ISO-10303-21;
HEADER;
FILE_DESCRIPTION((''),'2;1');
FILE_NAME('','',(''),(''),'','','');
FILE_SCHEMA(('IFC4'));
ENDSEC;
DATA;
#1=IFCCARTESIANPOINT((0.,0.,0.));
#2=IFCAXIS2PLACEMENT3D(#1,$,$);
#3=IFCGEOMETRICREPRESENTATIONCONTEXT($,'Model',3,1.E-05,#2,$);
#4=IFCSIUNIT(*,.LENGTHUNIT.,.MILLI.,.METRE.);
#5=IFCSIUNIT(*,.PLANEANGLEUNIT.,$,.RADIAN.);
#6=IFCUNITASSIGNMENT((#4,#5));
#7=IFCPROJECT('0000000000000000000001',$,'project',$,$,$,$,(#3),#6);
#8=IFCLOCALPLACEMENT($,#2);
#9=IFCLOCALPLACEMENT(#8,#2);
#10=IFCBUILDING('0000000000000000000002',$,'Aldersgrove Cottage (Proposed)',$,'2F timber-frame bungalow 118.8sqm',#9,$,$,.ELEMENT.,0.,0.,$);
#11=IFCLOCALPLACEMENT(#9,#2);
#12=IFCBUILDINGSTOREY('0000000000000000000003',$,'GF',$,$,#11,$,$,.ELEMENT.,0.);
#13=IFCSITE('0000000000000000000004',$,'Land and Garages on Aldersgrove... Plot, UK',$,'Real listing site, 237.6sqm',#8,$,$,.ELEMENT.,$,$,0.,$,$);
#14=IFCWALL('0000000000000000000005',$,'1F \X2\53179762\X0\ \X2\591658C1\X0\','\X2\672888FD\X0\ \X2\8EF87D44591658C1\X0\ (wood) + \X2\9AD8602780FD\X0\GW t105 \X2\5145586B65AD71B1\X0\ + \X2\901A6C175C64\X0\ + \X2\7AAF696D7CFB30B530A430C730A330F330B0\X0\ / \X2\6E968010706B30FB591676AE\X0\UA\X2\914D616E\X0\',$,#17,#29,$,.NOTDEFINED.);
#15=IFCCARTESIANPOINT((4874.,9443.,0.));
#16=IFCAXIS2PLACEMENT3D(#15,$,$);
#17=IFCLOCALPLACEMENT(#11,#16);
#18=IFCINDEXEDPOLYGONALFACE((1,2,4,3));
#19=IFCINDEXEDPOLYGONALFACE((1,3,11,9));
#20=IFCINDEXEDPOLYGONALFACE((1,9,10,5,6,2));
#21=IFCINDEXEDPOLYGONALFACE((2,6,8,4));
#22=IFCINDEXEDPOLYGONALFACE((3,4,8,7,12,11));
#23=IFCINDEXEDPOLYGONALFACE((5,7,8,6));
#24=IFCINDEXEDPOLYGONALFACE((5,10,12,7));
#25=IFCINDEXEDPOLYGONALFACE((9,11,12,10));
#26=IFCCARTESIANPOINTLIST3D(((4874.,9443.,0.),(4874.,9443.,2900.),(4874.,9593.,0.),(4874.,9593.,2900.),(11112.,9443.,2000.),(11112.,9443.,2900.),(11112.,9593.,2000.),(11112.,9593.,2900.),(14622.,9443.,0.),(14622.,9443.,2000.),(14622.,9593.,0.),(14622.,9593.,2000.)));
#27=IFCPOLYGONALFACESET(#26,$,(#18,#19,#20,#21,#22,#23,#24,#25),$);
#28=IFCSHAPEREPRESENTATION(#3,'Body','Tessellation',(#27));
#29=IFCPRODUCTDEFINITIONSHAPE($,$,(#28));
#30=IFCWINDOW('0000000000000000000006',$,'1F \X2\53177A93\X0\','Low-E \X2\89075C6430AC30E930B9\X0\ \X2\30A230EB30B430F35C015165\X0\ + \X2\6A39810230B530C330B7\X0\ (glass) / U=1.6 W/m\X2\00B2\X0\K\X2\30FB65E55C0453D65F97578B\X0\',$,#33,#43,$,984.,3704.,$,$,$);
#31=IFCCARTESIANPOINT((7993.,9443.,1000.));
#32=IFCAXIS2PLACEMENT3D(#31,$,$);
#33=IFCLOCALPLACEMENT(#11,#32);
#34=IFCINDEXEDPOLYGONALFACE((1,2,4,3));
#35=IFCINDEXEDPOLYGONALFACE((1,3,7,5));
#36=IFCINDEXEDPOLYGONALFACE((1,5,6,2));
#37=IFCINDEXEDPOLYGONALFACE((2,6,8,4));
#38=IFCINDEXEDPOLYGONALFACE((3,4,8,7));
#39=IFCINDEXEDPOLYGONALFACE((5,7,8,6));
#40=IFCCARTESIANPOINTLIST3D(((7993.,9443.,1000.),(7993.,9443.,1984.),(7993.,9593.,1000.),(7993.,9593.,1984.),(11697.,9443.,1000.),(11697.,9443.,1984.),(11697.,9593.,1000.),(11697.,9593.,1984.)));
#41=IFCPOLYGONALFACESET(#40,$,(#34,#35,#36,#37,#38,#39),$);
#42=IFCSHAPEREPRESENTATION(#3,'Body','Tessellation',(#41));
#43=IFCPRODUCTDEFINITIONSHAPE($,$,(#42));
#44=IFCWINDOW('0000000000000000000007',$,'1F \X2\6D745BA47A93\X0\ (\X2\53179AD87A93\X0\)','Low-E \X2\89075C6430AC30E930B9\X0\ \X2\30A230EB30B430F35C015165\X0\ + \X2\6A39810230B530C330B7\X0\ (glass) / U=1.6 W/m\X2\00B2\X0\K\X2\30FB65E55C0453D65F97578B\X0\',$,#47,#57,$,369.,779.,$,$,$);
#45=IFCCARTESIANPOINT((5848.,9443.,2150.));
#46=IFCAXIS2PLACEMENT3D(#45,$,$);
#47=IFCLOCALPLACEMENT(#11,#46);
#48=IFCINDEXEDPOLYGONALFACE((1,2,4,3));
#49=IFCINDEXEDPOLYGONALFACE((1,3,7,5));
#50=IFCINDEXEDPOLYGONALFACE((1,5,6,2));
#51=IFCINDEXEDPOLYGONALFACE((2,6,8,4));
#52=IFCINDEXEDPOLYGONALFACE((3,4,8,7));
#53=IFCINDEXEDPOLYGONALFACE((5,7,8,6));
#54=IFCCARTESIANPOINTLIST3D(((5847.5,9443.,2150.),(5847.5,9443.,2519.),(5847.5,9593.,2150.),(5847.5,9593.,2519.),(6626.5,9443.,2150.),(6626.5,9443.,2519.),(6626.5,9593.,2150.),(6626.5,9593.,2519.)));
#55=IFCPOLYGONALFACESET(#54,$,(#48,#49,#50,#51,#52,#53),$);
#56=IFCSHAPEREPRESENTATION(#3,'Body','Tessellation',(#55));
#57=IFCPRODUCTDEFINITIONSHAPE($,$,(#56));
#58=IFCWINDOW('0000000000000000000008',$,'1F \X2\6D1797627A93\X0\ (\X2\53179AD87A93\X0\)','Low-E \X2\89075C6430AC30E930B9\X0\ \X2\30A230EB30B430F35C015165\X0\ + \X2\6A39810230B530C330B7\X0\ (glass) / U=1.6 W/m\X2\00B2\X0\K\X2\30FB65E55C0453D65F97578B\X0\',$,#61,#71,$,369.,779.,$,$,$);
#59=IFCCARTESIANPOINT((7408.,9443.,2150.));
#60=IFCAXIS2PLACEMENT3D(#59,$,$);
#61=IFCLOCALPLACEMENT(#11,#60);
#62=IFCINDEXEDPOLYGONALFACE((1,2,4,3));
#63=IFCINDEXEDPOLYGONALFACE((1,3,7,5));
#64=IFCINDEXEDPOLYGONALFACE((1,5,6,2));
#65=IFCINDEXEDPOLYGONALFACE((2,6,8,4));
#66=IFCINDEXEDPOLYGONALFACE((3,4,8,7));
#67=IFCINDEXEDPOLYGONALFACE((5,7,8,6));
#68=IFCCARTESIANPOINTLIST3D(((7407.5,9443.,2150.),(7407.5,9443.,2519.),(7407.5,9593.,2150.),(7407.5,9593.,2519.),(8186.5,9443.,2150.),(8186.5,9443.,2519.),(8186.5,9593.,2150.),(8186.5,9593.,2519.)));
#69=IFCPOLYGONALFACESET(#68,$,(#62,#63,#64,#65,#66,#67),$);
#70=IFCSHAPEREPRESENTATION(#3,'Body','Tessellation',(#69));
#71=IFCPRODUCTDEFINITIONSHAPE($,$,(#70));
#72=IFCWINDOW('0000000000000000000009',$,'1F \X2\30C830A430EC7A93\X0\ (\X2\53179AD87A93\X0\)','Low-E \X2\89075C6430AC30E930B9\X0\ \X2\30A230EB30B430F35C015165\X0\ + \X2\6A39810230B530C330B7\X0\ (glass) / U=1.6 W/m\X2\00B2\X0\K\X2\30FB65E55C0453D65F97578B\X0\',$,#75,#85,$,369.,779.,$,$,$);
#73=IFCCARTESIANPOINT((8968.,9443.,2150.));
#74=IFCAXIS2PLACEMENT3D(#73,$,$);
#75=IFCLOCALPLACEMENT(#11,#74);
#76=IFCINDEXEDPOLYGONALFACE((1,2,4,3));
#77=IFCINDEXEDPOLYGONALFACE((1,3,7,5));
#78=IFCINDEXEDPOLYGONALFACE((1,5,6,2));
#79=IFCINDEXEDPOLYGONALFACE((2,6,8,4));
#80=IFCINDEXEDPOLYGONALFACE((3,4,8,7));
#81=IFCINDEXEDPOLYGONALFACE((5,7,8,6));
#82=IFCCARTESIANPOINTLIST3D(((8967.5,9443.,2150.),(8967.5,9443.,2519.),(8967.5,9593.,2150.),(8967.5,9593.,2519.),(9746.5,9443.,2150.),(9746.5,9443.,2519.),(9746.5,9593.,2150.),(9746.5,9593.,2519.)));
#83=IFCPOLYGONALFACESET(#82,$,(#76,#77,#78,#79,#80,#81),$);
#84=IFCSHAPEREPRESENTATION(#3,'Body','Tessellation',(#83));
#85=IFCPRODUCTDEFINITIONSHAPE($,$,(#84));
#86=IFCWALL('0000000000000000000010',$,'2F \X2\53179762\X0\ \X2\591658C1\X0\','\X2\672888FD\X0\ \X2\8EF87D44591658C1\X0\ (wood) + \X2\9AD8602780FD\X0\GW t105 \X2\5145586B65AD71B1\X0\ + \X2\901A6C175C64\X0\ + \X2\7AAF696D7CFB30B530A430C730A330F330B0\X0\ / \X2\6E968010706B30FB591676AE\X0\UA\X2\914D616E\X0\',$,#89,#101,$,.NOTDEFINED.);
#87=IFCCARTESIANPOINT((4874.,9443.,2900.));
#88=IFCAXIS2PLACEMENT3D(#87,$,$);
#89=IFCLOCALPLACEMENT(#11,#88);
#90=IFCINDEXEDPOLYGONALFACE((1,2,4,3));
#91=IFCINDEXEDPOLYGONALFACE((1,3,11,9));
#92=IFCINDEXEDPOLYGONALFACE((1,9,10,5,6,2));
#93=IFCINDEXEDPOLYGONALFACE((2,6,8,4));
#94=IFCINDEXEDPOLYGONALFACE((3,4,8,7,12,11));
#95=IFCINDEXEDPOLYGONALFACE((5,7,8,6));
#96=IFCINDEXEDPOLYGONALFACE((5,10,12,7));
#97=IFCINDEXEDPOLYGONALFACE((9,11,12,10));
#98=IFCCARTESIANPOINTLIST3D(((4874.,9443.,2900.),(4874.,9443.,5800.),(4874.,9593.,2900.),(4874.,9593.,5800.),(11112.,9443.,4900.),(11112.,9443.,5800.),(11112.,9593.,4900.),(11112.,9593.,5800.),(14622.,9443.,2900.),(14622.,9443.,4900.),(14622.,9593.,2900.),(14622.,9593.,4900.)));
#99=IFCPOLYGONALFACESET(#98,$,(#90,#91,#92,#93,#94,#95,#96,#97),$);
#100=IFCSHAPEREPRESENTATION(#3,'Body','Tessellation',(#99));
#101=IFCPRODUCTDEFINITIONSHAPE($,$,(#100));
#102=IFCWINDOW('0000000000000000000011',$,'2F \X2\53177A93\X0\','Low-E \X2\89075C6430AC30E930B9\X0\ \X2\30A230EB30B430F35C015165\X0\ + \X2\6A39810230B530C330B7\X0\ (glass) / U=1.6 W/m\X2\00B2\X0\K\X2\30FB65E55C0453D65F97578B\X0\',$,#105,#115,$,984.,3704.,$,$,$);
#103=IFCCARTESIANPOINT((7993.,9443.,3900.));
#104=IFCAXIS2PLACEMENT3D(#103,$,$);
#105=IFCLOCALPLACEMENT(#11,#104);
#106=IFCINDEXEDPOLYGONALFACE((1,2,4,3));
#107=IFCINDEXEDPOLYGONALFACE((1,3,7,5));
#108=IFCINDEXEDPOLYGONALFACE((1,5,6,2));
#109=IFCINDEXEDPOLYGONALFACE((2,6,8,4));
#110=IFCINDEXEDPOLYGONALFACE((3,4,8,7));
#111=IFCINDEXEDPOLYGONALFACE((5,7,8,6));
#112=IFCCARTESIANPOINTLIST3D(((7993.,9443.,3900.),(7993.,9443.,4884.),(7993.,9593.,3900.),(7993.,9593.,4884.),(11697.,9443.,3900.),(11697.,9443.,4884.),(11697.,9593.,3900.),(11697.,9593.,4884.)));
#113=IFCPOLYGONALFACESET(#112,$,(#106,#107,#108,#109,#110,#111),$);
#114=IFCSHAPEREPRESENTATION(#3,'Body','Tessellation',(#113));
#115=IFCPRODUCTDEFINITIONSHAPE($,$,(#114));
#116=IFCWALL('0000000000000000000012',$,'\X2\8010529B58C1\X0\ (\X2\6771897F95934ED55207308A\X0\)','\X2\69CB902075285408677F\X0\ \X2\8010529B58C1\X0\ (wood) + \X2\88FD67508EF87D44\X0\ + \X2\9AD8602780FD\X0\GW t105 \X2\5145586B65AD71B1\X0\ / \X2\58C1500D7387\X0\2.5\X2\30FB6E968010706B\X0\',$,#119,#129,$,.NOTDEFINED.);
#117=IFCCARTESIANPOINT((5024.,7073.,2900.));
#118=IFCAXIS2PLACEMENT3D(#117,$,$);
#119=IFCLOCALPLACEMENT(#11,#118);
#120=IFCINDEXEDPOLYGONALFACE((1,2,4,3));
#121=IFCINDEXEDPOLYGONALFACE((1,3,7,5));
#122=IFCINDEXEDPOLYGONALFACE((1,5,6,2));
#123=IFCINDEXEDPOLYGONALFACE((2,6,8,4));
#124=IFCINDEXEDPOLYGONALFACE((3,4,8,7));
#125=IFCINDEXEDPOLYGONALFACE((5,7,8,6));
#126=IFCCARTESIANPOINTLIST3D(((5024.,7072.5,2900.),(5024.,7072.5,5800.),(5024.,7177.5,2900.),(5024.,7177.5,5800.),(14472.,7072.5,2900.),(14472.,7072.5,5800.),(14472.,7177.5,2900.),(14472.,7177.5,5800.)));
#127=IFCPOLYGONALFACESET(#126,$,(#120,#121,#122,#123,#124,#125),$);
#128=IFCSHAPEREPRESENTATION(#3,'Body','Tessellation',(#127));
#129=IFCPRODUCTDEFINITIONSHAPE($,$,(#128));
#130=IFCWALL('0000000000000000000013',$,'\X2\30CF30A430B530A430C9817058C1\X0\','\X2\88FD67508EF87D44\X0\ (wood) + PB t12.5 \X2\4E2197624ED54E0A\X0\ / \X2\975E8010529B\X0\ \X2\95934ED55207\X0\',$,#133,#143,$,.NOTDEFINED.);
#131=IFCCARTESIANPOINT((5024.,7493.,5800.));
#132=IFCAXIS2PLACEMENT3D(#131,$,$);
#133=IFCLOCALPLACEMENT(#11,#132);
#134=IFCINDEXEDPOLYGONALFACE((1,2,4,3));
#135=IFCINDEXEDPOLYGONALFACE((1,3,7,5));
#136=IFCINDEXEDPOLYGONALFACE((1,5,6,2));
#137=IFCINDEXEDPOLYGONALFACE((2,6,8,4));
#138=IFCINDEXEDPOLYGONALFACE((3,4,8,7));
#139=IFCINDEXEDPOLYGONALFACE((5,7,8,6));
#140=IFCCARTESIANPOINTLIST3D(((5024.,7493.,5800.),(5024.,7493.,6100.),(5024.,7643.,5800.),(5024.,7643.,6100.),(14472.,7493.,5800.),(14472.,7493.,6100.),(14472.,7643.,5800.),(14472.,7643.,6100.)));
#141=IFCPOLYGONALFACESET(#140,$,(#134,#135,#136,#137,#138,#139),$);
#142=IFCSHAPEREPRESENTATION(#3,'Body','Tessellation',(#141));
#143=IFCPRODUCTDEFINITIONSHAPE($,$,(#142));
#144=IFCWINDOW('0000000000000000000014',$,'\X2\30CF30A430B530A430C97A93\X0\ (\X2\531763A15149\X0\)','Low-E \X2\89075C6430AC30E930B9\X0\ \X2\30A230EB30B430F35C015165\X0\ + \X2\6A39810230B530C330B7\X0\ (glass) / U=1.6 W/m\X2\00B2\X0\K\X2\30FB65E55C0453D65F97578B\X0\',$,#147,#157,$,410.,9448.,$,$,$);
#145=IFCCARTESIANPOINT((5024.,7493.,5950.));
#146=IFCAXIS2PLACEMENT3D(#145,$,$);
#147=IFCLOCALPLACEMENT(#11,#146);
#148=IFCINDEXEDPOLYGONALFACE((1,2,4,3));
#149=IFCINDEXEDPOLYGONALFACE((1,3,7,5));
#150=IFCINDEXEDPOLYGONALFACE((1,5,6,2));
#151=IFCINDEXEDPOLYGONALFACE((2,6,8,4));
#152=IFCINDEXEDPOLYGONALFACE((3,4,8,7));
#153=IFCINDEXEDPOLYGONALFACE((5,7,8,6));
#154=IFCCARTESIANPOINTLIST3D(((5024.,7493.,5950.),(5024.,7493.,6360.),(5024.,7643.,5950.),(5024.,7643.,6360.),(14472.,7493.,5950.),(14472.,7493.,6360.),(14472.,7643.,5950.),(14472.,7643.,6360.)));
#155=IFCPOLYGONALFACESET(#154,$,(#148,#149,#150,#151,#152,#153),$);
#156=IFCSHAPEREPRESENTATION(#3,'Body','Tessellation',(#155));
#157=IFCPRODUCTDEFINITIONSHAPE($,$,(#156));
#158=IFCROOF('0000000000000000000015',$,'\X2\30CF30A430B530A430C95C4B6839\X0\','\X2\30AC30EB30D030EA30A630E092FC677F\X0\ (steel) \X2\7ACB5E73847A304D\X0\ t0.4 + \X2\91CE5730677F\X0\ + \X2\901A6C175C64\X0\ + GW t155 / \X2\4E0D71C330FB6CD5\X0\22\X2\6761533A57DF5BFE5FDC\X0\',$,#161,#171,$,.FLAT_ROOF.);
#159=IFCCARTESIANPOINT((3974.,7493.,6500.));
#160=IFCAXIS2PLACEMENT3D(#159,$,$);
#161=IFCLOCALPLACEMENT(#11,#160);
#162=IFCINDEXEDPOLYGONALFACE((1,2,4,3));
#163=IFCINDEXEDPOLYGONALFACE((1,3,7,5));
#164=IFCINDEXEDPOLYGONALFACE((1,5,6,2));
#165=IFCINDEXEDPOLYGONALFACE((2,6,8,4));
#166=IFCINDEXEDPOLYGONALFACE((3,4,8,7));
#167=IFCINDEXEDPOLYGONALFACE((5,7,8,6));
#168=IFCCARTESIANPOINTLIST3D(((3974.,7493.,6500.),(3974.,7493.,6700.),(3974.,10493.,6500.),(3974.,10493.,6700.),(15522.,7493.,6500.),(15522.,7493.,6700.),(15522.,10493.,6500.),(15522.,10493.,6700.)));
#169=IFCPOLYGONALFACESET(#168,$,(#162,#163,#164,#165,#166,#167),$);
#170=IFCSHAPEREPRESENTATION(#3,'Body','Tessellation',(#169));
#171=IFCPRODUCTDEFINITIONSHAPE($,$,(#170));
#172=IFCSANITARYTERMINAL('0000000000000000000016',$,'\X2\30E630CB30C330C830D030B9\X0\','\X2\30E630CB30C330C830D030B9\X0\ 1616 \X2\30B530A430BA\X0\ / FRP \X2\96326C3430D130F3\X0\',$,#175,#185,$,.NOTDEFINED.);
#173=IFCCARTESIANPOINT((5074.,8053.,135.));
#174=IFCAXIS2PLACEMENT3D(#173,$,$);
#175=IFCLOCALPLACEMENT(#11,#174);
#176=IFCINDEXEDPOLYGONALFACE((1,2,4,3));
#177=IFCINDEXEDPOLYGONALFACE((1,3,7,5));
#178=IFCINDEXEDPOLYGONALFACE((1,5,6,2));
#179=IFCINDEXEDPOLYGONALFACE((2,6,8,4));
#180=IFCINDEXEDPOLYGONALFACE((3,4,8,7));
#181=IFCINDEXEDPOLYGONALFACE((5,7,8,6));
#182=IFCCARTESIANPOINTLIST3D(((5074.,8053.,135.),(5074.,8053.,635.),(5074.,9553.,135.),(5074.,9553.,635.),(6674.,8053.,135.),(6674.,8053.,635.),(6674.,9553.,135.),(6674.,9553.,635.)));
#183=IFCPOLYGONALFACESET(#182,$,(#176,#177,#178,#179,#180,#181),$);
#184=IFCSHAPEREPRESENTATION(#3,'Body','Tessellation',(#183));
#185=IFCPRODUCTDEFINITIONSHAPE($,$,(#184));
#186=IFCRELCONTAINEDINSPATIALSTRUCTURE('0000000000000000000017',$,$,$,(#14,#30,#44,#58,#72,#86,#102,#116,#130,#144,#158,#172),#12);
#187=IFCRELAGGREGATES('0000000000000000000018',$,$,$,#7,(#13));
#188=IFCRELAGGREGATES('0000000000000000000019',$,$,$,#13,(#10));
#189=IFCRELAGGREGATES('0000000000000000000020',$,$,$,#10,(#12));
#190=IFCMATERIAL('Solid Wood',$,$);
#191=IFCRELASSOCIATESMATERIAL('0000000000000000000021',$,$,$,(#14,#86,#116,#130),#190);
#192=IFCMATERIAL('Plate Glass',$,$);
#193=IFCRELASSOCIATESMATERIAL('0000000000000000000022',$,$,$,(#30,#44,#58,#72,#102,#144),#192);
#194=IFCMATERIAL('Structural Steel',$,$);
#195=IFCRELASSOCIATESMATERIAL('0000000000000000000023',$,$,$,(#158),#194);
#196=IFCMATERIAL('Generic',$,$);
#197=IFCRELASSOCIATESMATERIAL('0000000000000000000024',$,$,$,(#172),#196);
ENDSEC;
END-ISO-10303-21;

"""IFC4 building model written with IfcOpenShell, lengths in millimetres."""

from ifc_helpers import new_model, si_unit, frame, frame_2d, origin, place, context, project, spatial, rectangle, extrude, material, element, fill, save


model = new_model("IFC4")

# Units and contexts
model_context = context("Model", 3, precision=1e-05, world=origin())
ifc_project = project(units=[si_unit("LENGTHUNIT", "METRE", prefix="MILLI"), si_unit("PLANEANGLEUNIT", "RADIAN")], contexts=[model_context])

# Site, building, storey
site_placement = place(None, origin())
site = spatial("IfcSite", under=ifc_project, at=site_placement, Name="Land and Garages on Aldersgrove... Plot, UK", ObjectType="Real listing site, 237.6sqm", CompositionType="ELEMENT", RefElevation=0.0)
building_placement = place(site_placement, origin())
building = spatial("IfcBuilding", under=site, at=building_placement, Name="Aldersgrove Cottage (Proposed)", ObjectType="2F timber-frame bungalow 118.8sqm", CompositionType="ELEMENT", ElevationOfRefHeight=0.0, ElevationOfTerrain=0.0)
storey_placement = place(building_placement, origin())
storey = spatial("IfcBuildingStorey", under=building, at=storey_placement, Name="GF", CompositionType="ELEMENT", Elevation=0.0)

# Wall, openings, windows
ifc_material_1 = material(Name="Solid Wood")
wall_1_placement = place(storey_placement, frame((4874.0, 9443.0, 0.0)))
wall_1 = element("IfcWall", 1, at=wall_1_placement, inside=storey, material=ifc_material_1, Name="1F 北面 外壁", Description="木製 軸組外壁 (wood) + 高性能GW t105 充填断熱 + 通気層 + 窯業系サイディング / 準耐火・外皮UA配慮", PredefinedType="NOTDEFINED", context=model_context, shape_type="SweptSolid", body=[
    extrude(rectangle(XDim=9748.0, YDim=150.0, at=frame_2d((4874.0, 75.0))), frame((4874.0, 9443.0, 0.0)), (0.0, 0.0, 1.0), 2900.0),
])
opening_1_placement = place(storey_placement, frame((7993.0, 9443.0, 1000.0)))
opening_1 = element("IfcOpeningElement", 2, at=opening_1_placement, cuts=wall_1, PredefinedType="NOTDEFINED", context=model_context, shape_type="SweptSolid", body=[
    extrude(rectangle(XDim=3704.0, YDim=150.0, at=frame_2d((1852.0, 75.0))), frame((7993.0, 9443.0, 1000.0)), (0.0, 0.0, 1.0), 984.0),
])
opening_2_placement = place(storey_placement, frame((5848.0, 9443.0, 2150.0)))
opening_2 = element("IfcOpeningElement", 3, at=opening_2_placement, cuts=wall_1, PredefinedType="NOTDEFINED", context=model_context, shape_type="SweptSolid", body=[
    extrude(rectangle(XDim=779.0, YDim=150.0, at=frame_2d((389.0, 75.0))), frame((5848.0, 9443.0, 2150.0)), (0.0, 0.0, 1.0), 369.0),
])
opening_3_placement = place(storey_placement, frame((7408.0, 9443.0, 2150.0)))
opening_3 = element("IfcOpeningElement", 4, at=opening_3_placement, cuts=wall_1, PredefinedType="NOTDEFINED", context=model_context, shape_type="SweptSolid", body=[
    extrude(rectangle(XDim=779.0, YDim=150.0, at=frame_2d((389.0, 75.0))), frame((7408.0, 9443.0, 2150.0)), (0.0, 0.0, 1.0), 369.0),
])
opening_4_placement = place(storey_placement, frame((8968.0, 9443.0, 2150.0)))
opening_4 = element("IfcOpeningElement", 5, at=opening_4_placement, cuts=wall_1, PredefinedType="NOTDEFINED", context=model_context, shape_type="SweptSolid", body=[
    extrude(rectangle(XDim=779.0, YDim=150.0, at=frame_2d((389.0, 75.0))), frame((8968.0, 9443.0, 2150.0)), (0.0, 0.0, 1.0), 369.0),
])
ifc_material_2 = material(Name="Plate Glass")
window_1_placement = place(storey_placement, frame((7993.0, 9443.0, 1000.0)))
window_1 = element("IfcWindow", 6, at=window_1_placement, inside=storey, material=ifc_material_2, Name="1F 北窓", Description="Low-E 複層ガラス アルゴン封入 + 樹脂サッシ (glass) / U=1.6 W/m²K・日射取得型", OverallHeight=984.0, OverallWidth=3704.0, context=model_context, shape_type="SweptSolid", body=[
    extrude(rectangle(XDim=3704.0, YDim=150.0, at=frame_2d((1852.0, 75.0))), frame((7993.0, 9443.0, 1000.0)), (0.0, 0.0, 1.0), 984.0),
])
fill(opening_1, window_1)
window_2_placement = place(storey_placement, frame((5848.0, 9443.0, 2150.0)))
window_2 = element("IfcWindow", 7, at=window_2_placement, inside=storey, material=ifc_material_2, Name="1F 浴室窓 (北高窓)", Description="Low-E 複層ガラス アルゴン封入 + 樹脂サッシ (glass) / U=1.6 W/m²K・日射取得型", OverallHeight=369.0, OverallWidth=779.0, context=model_context, shape_type="SweptSolid", body=[
    extrude(rectangle(XDim=779.0, YDim=150.0, at=frame_2d((389.0, 75.0))), frame((5848.0, 9443.0, 2150.0)), (0.0, 0.0, 1.0), 369.0),
])
fill(opening_2, window_2)
window_3_placement = place(storey_placement, frame((7408.0, 9443.0, 2150.0)))
window_3 = element("IfcWindow", 8, at=window_3_placement, inside=storey, material=ifc_material_2, Name="1F 洗面窓 (北高窓)", Description="Low-E 複層ガラス アルゴン封入 + 樹脂サッシ (glass) / U=1.6 W/m²K・日射取得型", OverallHeight=369.0, OverallWidth=779.0, context=model_context, shape_type="SweptSolid", body=[
    extrude(rectangle(XDim=779.0, YDim=150.0, at=frame_2d((389.0, 75.0))), frame((7408.0, 9443.0, 2150.0)), (0.0, 0.0, 1.0), 369.0),
])
fill(opening_3, window_3)
window_4_placement = place(storey_placement, frame((8968.0, 9443.0, 2150.0)))
window_4 = element("IfcWindow", 9, at=window_4_placement, inside=storey, material=ifc_material_2, Name="1F トイレ窓 (北高窓)", Description="Low-E 複層ガラス アルゴン封入 + 樹脂サッシ (glass) / U=1.6 W/m²K・日射取得型", OverallHeight=369.0, OverallWidth=779.0, context=model_context, shape_type="SweptSolid", body=[
    extrude(rectangle(XDim=779.0, YDim=150.0, at=frame_2d((389.0, 75.0))), frame((8968.0, 9443.0, 2150.0)), (0.0, 0.0, 1.0), 369.0),
])
fill(opening_4, window_4)

# Wall, opening, window
wall_2_placement = place(storey_placement, frame((4874.0, 9443.0, 2900.0)))
wall_2 = element("IfcWall", 10, at=wall_2_placement, inside=storey, material=ifc_material_1, Name="2F 北面 外壁", Description="木製 軸組外壁 (wood) + 高性能GW t105 充填断熱 + 通気層 + 窯業系サイディング / 準耐火・外皮UA配慮", PredefinedType="NOTDEFINED", context=model_context, shape_type="SweptSolid", body=[
    extrude(rectangle(XDim=9748.0, YDim=150.0, at=frame_2d((4874.0, 75.0))), frame((4874.0, 9443.0, 2900.0)), (0.0, 0.0, 1.0), 2900.0),
])
opening_5_placement = place(storey_placement, frame((7993.0, 9443.0, 3900.0)))
opening_5 = element("IfcOpeningElement", 11, at=opening_5_placement, cuts=wall_2, PredefinedType="NOTDEFINED", context=model_context, shape_type="SweptSolid", body=[
    extrude(rectangle(XDim=3704.0, YDim=150.0, at=frame_2d((1852.0, 75.0))), frame((7993.0, 9443.0, 3900.0)), (0.0, 0.0, 1.0), 984.0),
])
window_5_placement = place(storey_placement, frame((7993.0, 9443.0, 3900.0)))
window_5 = element("IfcWindow", 12, at=window_5_placement, inside=storey, material=ifc_material_2, Name="2F 北窓", Description="Low-E 複層ガラス アルゴン封入 + 樹脂サッシ (glass) / U=1.6 W/m²K・日射取得型", OverallHeight=984.0, OverallWidth=3704.0, context=model_context, shape_type="SweptSolid", body=[
    extrude(rectangle(XDim=3704.0, YDim=150.0, at=frame_2d((1852.0, 75.0))), frame((7993.0, 9443.0, 3900.0)), (0.0, 0.0, 1.0), 984.0),
])
fill(opening_5, window_5)

# Wall
wall_3_placement = place(storey_placement, frame((5024.0, 7073.0, 2900.0)))
element("IfcWall", 13, at=wall_3_placement, inside=storey, material=ifc_material_1, Name="耐力壁 (東西間仕切り)", Description="構造用合板 耐力壁 (wood) + 製材軸組 + 高性能GW t105 充填断熱 / 壁倍率2.5・準耐火", PredefinedType="NOTDEFINED", context=model_context, shape_type="SweptSolid", body=[
    extrude(rectangle(XDim=9448.0, YDim=105.0, at=frame_2d((4724.0, 52.0))), frame((5024.0, 7073.0, 2900.0)), (0.0, 0.0, 1.0), 2900.0),
])

# Wall, opening, window
wall_4_placement = place(storey_placement, frame((5024.0, 7493.0, 5800.0)))
wall_4 = element("IfcWall", 14, at=wall_4_placement, inside=storey, material=ifc_material_1, Name="ハイサイド腰壁", Description="製材軸組 (wood) + PB t12.5 両面仕上 / 非耐力 間仕切", PredefinedType="NOTDEFINED", context=model_context, shape_type="SweptSolid", body=[
    extrude(rectangle(XDim=9448.0, YDim=150.0, at=frame_2d((4724.0, 75.0))), frame((5024.0, 7493.0, 5800.0)), (0.0, 0.0, 1.0), 700.0),
])
opening_6_placement = place(storey_placement, frame((5024.0, 7493.0, 5950.0)))
opening_6 = element("IfcOpeningElement", 15, at=opening_6_placement, cuts=wall_4, PredefinedType="NOTDEFINED", context=model_context, shape_type="SweptSolid", body=[
    extrude(rectangle(XDim=9448.0, YDim=150.0, at=frame_2d((4724.0, 75.0))), frame((5024.0, 7493.0, 5950.0)), (0.0, 0.0, 1.0), 410.0),
])
window_6_placement = place(storey_placement, frame((5024.0, 7493.0, 5950.0)))
window_6 = element("IfcWindow", 16, at=window_6_placement, inside=storey, material=ifc_material_2, Name="ハイサイド窓 (北採光)", Description="Low-E 複層ガラス アルゴン封入 + 樹脂サッシ (glass) / U=1.6 W/m²K・日射取得型", OverallHeight=410.0, OverallWidth=9448.0, context=model_context, shape_type="SweptSolid", body=[
    extrude(rectangle(XDim=9448.0, YDim=150.0, at=frame_2d((4724.0, 75.0))), frame((5024.0, 7493.0, 5950.0)), (0.0, 0.0, 1.0), 410.0),
])
fill(opening_6, window_6)

# Roof
ifc_material_3 = material(Name="Structural Steel")
roof_placement = place(storey_placement, frame((3974.0, 7493.0, 6500.0)))
element("IfcRoof", 17, at=roof_placement, inside=storey, material=ifc_material_3, Name="ハイサイド屋根", Description="ガルバリウム鋼板 (steel) 立平葺き t0.4 + 野地板 + 通気層 + GW t155 / 不燃・法22条区域対応", PredefinedType="FLAT_ROOF", context=model_context, shape_type="SweptSolid", body=[
    extrude(rectangle(XDim=11548.0, YDim=3000.0, at=frame_2d((5774.0, 1500.0))), frame((3974.0, 7493.0, 6500.0)), (0.0, 0.0, 1.0), 200.0),
])

# Sanitary terminal
ifc_material_4 = material(Name="Generic")
sanitary_terminal_placement = place(storey_placement, frame((5074.0, 8053.0, 135.0)))
element("IfcSanitaryTerminal", 18, at=sanitary_terminal_placement, inside=storey, material=ifc_material_4, Name="ユニットバス", Description="ユニットバス 1616 サイズ / FRP 防水パン", PredefinedType="NOTDEFINED", context=model_context, shape_type="SweptSolid", body=[
    extrude(rectangle(XDim=1600.0, YDim=1500.0, at=frame_2d((800.0, 750.0))), frame((5074.0, 8053.0, 135.0)), (0.0, 0.0, 1.0), 500.0),
])

save(model, "model.ifc")
